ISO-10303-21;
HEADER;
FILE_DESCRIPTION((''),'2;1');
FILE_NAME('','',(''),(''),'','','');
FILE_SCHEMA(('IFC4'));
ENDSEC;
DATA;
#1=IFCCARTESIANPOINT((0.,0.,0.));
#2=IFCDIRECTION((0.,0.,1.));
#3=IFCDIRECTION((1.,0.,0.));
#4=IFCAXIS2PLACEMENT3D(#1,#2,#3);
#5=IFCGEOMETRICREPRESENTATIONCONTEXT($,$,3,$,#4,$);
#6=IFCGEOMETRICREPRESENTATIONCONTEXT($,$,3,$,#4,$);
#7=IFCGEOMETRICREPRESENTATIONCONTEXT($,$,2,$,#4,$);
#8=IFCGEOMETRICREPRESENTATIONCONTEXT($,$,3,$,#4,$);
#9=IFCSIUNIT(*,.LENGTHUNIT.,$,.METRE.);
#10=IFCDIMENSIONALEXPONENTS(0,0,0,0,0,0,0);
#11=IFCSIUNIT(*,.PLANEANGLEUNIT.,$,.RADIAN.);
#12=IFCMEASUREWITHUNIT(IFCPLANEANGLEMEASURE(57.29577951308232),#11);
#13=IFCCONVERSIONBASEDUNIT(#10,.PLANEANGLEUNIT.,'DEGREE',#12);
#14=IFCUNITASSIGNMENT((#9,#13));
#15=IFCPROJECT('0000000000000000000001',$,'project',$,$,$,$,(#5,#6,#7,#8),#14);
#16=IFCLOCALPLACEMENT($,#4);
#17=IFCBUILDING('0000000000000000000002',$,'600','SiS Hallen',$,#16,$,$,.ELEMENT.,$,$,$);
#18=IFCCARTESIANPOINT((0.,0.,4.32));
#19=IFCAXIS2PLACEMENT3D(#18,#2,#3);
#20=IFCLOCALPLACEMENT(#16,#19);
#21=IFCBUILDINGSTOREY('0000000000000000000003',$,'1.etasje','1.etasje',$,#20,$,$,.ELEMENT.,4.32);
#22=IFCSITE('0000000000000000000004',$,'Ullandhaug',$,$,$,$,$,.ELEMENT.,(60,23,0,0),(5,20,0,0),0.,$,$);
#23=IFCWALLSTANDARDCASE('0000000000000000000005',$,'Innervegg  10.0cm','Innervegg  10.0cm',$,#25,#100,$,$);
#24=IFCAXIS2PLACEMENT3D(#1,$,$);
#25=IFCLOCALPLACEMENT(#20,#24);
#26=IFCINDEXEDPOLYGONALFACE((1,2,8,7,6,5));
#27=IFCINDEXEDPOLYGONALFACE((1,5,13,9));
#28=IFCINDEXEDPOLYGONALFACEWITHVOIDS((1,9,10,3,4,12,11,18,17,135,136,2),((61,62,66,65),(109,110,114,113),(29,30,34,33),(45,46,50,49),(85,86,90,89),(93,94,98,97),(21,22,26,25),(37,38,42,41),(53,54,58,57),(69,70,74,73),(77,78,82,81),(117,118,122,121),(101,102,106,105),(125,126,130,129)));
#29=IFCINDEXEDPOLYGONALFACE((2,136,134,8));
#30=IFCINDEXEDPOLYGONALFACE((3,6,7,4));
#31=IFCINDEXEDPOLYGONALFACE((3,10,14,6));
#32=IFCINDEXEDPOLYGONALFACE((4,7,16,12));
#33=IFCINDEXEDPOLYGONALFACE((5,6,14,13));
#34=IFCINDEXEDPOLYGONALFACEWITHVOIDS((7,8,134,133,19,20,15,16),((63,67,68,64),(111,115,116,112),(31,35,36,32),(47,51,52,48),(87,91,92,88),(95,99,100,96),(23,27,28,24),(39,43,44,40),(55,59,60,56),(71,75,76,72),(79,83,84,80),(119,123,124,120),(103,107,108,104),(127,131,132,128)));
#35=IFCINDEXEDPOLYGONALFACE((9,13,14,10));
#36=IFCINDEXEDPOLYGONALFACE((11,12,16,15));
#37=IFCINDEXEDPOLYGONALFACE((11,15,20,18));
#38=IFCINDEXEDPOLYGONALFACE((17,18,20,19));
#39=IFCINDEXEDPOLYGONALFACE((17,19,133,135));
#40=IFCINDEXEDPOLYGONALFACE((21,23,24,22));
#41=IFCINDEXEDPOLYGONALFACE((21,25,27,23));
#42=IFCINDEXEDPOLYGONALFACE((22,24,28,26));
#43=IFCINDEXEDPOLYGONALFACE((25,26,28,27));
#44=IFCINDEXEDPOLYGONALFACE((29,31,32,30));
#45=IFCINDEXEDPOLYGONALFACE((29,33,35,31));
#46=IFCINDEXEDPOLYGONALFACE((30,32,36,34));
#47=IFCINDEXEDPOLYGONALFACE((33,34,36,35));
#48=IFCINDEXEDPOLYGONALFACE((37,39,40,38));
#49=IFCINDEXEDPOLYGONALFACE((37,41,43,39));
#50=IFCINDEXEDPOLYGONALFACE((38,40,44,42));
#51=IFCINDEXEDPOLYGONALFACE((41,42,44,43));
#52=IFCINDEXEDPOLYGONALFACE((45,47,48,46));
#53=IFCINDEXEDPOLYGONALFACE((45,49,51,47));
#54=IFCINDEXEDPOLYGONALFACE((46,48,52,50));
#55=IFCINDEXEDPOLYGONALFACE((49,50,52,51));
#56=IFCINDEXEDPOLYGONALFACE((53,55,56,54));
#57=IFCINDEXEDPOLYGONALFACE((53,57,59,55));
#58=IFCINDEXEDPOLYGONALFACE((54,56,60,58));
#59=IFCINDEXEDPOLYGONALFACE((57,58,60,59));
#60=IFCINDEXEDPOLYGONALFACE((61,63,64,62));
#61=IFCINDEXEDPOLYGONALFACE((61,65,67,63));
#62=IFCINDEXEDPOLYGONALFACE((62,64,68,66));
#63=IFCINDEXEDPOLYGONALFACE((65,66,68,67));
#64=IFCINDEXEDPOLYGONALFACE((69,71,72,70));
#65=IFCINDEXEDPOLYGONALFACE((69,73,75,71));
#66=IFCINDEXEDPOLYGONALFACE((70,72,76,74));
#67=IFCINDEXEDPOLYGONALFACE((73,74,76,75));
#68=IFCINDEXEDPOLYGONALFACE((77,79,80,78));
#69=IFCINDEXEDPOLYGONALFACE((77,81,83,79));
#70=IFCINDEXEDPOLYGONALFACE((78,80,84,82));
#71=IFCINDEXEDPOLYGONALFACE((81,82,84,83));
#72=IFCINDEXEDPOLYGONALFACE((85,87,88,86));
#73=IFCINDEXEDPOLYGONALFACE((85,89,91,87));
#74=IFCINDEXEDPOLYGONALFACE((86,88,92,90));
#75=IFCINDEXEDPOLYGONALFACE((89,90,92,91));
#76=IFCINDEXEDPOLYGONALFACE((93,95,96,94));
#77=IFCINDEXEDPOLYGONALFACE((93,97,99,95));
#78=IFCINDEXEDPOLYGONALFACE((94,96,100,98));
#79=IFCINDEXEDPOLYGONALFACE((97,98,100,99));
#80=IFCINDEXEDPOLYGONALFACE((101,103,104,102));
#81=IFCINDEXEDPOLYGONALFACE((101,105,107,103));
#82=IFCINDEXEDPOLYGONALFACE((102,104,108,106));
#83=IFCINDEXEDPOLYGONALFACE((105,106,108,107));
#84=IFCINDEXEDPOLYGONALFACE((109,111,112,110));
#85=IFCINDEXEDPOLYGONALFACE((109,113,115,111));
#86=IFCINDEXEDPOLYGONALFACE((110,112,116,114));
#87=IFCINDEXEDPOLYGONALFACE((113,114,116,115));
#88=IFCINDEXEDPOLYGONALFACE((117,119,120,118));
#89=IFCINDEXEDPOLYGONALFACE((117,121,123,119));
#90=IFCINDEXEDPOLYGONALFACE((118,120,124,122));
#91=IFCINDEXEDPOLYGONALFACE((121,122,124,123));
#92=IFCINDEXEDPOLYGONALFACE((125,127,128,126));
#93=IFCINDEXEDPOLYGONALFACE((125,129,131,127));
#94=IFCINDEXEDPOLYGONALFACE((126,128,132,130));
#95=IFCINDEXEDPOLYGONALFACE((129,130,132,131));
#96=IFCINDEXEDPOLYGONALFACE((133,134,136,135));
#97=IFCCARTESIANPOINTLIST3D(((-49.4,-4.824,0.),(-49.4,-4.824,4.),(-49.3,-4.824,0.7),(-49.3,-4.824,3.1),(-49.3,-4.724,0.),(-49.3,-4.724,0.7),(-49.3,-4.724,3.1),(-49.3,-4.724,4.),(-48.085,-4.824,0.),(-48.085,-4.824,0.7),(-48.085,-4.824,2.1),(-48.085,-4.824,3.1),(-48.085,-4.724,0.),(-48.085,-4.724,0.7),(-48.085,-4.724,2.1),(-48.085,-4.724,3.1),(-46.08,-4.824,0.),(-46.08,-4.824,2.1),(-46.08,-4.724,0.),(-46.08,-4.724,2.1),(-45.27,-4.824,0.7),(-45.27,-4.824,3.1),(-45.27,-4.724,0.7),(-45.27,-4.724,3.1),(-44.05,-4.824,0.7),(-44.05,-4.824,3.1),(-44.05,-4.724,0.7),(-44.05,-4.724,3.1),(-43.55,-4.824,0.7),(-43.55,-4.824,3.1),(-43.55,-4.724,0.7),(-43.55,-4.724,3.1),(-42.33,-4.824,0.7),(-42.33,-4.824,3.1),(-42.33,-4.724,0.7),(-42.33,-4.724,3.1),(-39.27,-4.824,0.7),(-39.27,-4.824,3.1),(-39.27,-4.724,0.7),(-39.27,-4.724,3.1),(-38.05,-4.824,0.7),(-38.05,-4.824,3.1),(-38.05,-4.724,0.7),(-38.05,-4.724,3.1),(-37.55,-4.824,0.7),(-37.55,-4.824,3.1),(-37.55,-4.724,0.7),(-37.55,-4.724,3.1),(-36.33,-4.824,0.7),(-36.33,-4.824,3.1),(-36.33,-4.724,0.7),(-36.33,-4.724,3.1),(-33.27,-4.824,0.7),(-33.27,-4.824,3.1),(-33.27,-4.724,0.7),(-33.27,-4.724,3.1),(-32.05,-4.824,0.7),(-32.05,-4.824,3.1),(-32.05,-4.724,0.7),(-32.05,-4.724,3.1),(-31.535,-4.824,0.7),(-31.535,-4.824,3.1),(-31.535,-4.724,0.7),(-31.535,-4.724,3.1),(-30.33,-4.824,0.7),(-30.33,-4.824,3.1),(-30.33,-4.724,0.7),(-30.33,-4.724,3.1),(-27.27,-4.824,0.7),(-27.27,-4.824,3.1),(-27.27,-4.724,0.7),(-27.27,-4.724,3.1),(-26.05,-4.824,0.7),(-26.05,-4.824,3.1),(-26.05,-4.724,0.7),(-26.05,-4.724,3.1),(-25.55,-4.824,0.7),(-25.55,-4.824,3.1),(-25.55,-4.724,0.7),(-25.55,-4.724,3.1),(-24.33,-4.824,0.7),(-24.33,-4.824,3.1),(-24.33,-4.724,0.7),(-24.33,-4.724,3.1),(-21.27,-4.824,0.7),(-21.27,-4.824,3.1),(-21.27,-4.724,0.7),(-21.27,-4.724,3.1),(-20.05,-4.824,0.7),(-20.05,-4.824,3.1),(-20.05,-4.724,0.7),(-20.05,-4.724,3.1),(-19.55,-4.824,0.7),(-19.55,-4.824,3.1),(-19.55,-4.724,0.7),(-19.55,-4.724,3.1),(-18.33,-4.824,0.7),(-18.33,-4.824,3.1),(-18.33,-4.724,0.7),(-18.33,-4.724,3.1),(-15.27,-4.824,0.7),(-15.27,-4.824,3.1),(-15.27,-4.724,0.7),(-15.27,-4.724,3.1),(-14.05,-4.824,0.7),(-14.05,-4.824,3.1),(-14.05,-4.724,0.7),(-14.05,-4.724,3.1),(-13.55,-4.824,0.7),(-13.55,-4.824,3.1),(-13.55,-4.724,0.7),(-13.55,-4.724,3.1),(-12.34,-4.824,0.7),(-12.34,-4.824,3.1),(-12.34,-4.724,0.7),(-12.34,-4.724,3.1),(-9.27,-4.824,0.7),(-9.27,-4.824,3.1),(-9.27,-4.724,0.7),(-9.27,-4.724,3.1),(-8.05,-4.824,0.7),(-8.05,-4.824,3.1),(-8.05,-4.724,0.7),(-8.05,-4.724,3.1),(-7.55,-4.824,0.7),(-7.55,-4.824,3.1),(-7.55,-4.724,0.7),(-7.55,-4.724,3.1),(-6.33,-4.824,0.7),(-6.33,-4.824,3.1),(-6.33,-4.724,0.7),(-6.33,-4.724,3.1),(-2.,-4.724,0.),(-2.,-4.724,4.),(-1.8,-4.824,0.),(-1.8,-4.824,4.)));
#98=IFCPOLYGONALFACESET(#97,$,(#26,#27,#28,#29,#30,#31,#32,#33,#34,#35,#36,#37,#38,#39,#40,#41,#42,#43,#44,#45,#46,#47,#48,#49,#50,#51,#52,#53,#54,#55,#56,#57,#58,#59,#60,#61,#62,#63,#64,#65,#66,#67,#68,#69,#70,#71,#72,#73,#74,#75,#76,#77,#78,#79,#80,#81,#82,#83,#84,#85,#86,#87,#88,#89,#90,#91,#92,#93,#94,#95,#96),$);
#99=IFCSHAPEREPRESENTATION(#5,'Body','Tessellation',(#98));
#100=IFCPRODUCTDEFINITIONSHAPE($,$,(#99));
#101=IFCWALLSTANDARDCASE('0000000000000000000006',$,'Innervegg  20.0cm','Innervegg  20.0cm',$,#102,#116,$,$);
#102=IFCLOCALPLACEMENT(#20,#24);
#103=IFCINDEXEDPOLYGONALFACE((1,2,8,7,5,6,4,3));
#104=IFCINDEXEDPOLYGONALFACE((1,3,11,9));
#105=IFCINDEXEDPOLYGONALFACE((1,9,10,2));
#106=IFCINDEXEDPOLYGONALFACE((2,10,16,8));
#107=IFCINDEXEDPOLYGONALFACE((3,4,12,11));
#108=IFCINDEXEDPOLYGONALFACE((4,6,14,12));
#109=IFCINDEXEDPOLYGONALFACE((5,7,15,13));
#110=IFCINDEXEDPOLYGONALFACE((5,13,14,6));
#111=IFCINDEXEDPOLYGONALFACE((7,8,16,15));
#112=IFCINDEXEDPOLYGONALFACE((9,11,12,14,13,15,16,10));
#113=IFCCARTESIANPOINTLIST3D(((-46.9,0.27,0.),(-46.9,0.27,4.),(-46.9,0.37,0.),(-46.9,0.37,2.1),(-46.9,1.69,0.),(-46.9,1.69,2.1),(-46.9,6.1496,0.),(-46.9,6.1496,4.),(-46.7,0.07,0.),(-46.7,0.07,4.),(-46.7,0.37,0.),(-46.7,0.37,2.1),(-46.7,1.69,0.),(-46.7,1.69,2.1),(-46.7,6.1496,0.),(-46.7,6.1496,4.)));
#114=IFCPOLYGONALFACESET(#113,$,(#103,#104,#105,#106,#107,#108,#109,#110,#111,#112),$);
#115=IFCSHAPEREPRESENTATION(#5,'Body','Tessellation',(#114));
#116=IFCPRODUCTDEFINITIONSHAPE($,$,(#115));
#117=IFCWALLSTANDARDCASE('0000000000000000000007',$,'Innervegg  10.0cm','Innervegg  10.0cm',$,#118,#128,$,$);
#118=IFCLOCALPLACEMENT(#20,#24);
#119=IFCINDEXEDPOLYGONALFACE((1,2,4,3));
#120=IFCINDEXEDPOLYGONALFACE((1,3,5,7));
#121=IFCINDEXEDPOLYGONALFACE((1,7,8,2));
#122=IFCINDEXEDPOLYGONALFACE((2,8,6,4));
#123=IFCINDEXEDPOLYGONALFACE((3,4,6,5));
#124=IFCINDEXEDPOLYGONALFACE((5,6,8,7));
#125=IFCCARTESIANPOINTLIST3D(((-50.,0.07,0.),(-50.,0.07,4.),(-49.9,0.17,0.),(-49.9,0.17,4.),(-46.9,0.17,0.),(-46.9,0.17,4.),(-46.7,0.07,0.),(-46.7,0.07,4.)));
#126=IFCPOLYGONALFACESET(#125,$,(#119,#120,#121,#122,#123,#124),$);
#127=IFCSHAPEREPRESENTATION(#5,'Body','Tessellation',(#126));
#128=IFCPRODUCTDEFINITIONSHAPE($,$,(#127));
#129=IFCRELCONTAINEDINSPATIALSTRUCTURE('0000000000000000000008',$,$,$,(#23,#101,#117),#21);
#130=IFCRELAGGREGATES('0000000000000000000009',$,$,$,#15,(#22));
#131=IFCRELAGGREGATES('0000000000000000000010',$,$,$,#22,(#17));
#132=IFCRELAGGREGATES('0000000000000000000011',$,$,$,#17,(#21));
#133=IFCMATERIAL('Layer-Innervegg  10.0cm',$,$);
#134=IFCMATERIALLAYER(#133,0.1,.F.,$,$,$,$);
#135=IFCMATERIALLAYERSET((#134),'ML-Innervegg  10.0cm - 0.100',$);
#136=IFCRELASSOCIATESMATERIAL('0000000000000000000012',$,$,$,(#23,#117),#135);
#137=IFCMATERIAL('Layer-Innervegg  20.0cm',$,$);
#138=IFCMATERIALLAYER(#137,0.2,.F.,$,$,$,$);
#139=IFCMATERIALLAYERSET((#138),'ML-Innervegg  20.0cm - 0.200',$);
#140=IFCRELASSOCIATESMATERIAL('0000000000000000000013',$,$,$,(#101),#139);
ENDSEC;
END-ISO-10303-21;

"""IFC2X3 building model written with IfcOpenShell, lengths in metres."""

from ifc_helpers import new_model, entity, si_unit, converted_unit, frame, origin_with_axes, place, context, project, spatial, polyline, outline, extrude, material, layer, layer_set, layer_usage, element, save


model = new_model("IFC2X3")

# Units and contexts
context_of_model_1 = context(None, 3, world=origin_with_axes())
context_of_model_2 = context(None, 3, world=origin_with_axes())
context_of_model_3 = context(None, 2, world=origin_with_axes())
context_of_model_4 = context(None, 3, world=origin_with_axes())
ifc_project = project(units=[si_unit("LENGTHUNIT", "METRE"), converted_unit("PLANEANGLEUNIT", "DEGREE", entity("IfcPlaneAngleMeasure", 57.29577951308232), si_unit("PLANEANGLEUNIT", "RADIAN"), dimensions=[0, 0, 0, 0, 0, 0, 0])], contexts=[context_of_model_1, context_of_model_2, context_of_model_3, context_of_model_4])

# Site, building, storey
site = spatial("IfcSite", under=ifc_project, Name="Ullandhaug", CompositionType="ELEMENT", RefLatitude=(60, 23, 0, 0), RefLongitude=(5, 20, 0, 0), RefElevation=0.0)
building_placement = place(None, origin_with_axes())
building = spatial("IfcBuilding", under=site, at=building_placement, Name="600", Description="SiS Hallen", CompositionType="ELEMENT")
storey_placement = place(building_placement, frame((0.0, 0.0, 4.32), z_axis=(0.0, 0.0, 1.0), x_axis=(1.0, 0.0, 0.0)))
storey = spatial("IfcBuildingStorey", under=building, at=storey_placement, Name="1.etasje", Description="1.etasje", CompositionType="ELEMENT", Elevation=4.32)

# Shared definitions
ifc_material_1 = material(Name="Layer-Innervegg  20.0cm")
ifc_layer_1 = layer(ifc_material_1, 0.2, ventilated=False)
ifc_layer_set_1 = layer_set([ifc_layer_1], Name="ML-Innervegg  20.0cm - 0.200")
ifc_layer_usage_1 = layer_usage(ifc_layer_set_1, "AXIS2", "POSITIVE", 0.0)
ifc_material_2 = material(Name="Layer-Innervegg  10.0cm")
ifc_layer_2 = layer(ifc_material_2, 0.1, ventilated=False)
ifc_layer_set_2 = layer_set([ifc_layer_2], Name="ML-Innervegg  10.0cm - 0.100")
ifc_layer_usage_2 = layer_usage(ifc_layer_set_2, "AXIS2", "POSITIVE", 0.0)

# Wall, openings
wall_1_placement = place(storey_placement, frame((-49.4, -4.824, 0.0), z_axis=(0.0, 0.0, 1.0), x_axis=(1.0, 0.0, 0.0)))
wall_1 = element("IfcWallStandardCase", 1, at=wall_1_placement, inside=storey, material=ifc_layer_usage_2, Name="Innervegg  10.0cm", Description="Innervegg  10.0cm", context=context_of_model_1, shape_type="SweptSolid", body=[
    extrude(outline(polyline([(0.0, 0.0), (47.6, 0.0), (47.4, 0.1), (0.1, 0.1), (0.0, 0.0)])), origin_with_axes(), (0.0, 0.0, 1.0), 4.0),
])
opening_1_placement = place(wall_1_placement, frame((1.315, 0.1, 0.0), z_axis=(0.0, 0.0, 1.0), x_axis=(1.0, 0.0, 0.0)))
element("IfcOpeningElement", 2, at=opening_1_placement, cuts=wall_1, context=context_of_model_1, shape_type="SweptSolid", body=[
    extrude(outline(polyline([(0.0, 0.0), (2.1, 0.0), (2.1, 2.005), (0.0, 2.005), (0.0, 0.0)])), frame((0.0, 0.0, 0.0), z_axis=(0.0, 1.0, 0.0), x_axis=(0.0, 0.0, 1.0)), (0.0, 0.0, -1.0), 0.1),
])
opening_2_placement = place(wall_1_placement, frame((0.1, 0.1, 0.7), z_axis=(0.0, 0.0, 1.0), x_axis=(1.0, 0.0, 0.0)))
element("IfcOpeningElement", 3, at=opening_2_placement, cuts=wall_1, context=context_of_model_1, shape_type="SweptSolid", body=[
    extrude(outline(polyline([(0.0, 0.0), (2.4, 0.0), (2.4, 1.215), (0.0, 1.215), (0.0, 0.0)])), frame((0.0, 0.0, 0.0), z_axis=(0.0, 1.0, 0.0), x_axis=(0.0, 0.0, 1.0)), (0.0, 0.0, -1.0), 0.1),
])
opening_3_placement = place(wall_1_placement, frame((4.13, 0.1, 0.7), z_axis=(0.0, 0.0, 1.0), x_axis=(1.0, 0.0, 0.0)))
element("IfcOpeningElement", 4, at=opening_3_placement, cuts=wall_1, context=context_of_model_1, shape_type="SweptSolid", body=[
    extrude(outline(polyline([(0.0, 0.0), (2.4, 0.0), (2.4, 1.22), (0.0, 1.22), (0.0, 0.0)])), frame((0.0, 0.0, 0.0), z_axis=(0.0, 1.0, 0.0), x_axis=(0.0, 0.0, 1.0)), (0.0, 0.0, -1.0), 0.1),
])
opening_4_placement = place(wall_1_placement, frame((5.85, 0.1, 0.7), z_axis=(0.0, 0.0, 1.0), x_axis=(1.0, 0.0, 0.0)))
element("IfcOpeningElement", 5, at=opening_4_placement, cuts=wall_1, context=context_of_model_1, shape_type="SweptSolid", body=[
    extrude(outline(polyline([(0.0, 0.0), (2.4, 0.0), (2.4, 1.22), (0.0, 1.22), (0.0, 0.0)])), frame((0.0, 0.0, 0.0), z_axis=(0.0, 1.0, 0.0), x_axis=(0.0, 0.0, 1.0)), (0.0, 0.0, -1.0), 0.1),
])
opening_5_placement = place(wall_1_placement, frame((10.13, 0.1, 0.7), z_axis=(0.0, 0.0, 1.0), x_axis=(1.0, 0.0, 0.0)))
element("IfcOpeningElement", 6, at=opening_5_placement, cuts=wall_1, context=context_of_model_1, shape_type="SweptSolid", body=[
    extrude(outline(polyline([(0.0, 0.0), (2.4, 0.0), (2.4, 1.22), (0.0, 1.22), (0.0, 0.0)])), frame((0.0, 0.0, 0.0), z_axis=(0.0, 1.0, 0.0), x_axis=(0.0, 0.0, 1.0)), (0.0, 0.0, -1.0), 0.1),
])
opening_6_placement = place(wall_1_placement, frame((11.85, 0.1, 0.7), z_axis=(0.0, 0.0, 1.0), x_axis=(1.0, 0.0, 0.0)))
element("IfcOpeningElement", 7, at=opening_6_placement, cuts=wall_1, context=context_of_model_1, shape_type="SweptSolid", body=[
    extrude(outline(polyline([(0.0, 0.0), (2.4, 0.0), (2.4, 1.22), (0.0, 1.22), (0.0, 0.0)])), frame((0.0, 0.0, 0.0), z_axis=(0.0, 1.0, 0.0), x_axis=(0.0, 0.0, 1.0)), (0.0, 0.0, -1.0), 0.1),
])
opening_7_placement = place(wall_1_placement, frame((16.13, 0.1, 0.7), z_axis=(0.0, 0.0, 1.0), x_axis=(1.0, 0.0, 0.0)))
element("IfcOpeningElement", 8, at=opening_7_placement, cuts=wall_1, context=context_of_model_1, shape_type="SweptSolid", body=[
    extrude(outline(polyline([(0.0, 0.0), (2.4, 0.0), (2.4, 1.22), (0.0, 1.22), (0.0, 0.0)])), frame((0.0, 0.0, 0.0), z_axis=(0.0, 1.0, 0.0), x_axis=(0.0, 0.0, 1.0)), (0.0, 0.0, -1.0), 0.1),
])
opening_8_placement = place(wall_1_placement, frame((22.13, 0.1, 0.7), z_axis=(0.0, 0.0, 1.0), x_axis=(1.0, 0.0, 0.0)))
element("IfcOpeningElement", 9, at=opening_8_placement, cuts=wall_1, context=context_of_model_1, shape_type="SweptSolid", body=[
    extrude(outline(polyline([(0.0, 0.0), (2.4, 0.0), (2.4, 1.22), (0.0, 1.22), (0.0, 0.0)])), frame((0.0, 0.0, 0.0), z_axis=(0.0, 1.0, 0.0), x_axis=(0.0, 0.0, 1.0)), (0.0, 0.0, -1.0), 0.1),
])
opening_9_placement = place(wall_1_placement, frame((23.85, 0.1, 0.7), z_axis=(0.0, 0.0, 1.0), x_axis=(1.0, 0.0, 0.0)))
element("IfcOpeningElement", 10, at=opening_9_placement, cuts=wall_1, context=context_of_model_1, shape_type="SweptSolid", body=[
    extrude(outline(polyline([(0.0, 0.0), (2.4, 0.0), (2.4, 1.22), (0.0, 1.22), (0.0, 0.0)])), frame((0.0, 0.0, 0.0), z_axis=(0.0, 1.0, 0.0), x_axis=(0.0, 0.0, 1.0)), (0.0, 0.0, -1.0), 0.1),
])
opening_10_placement = place(wall_1_placement, frame((28.13, 0.1, 0.7), z_axis=(0.0, 0.0, 1.0), x_axis=(1.0, 0.0, 0.0)))
element("IfcOpeningElement", 11, at=opening_10_placement, cuts=wall_1, context=context_of_model_1, shape_type="SweptSolid", body=[
    extrude(outline(polyline([(0.0, 0.0), (2.4, 0.0), (2.4, 1.22), (0.0, 1.22), (0.0, 0.0)])), frame((0.0, 0.0, 0.0), z_axis=(0.0, 1.0, 0.0), x_axis=(0.0, 0.0, 1.0)), (0.0, 0.0, -1.0), 0.1),
])
opening_11_placement = place(wall_1_placement, frame((29.85, 0.1, 0.7), z_axis=(0.0, 0.0, 1.0), x_axis=(1.0, 0.0, 0.0)))
element("IfcOpeningElement", 12, at=opening_11_placement, cuts=wall_1, context=context_of_model_1, shape_type="SweptSolid", body=[
    extrude(outline(polyline([(0.0, 0.0), (2.4, 0.0), (2.4, 1.22), (0.0, 1.22), (0.0, 0.0)])), frame((0.0, 0.0, 0.0), z_axis=(0.0, 1.0, 0.0), x_axis=(0.0, 0.0, 1.0)), (0.0, 0.0, -1.0), 0.1),
])
opening_12_placement = place(wall_1_placement, frame((34.13, 0.1, 0.7), z_axis=(0.0, 0.0, 1.0), x_axis=(1.0, 0.0, 0.0)))
element("IfcOpeningElement", 13, at=opening_12_placement, cuts=wall_1, context=context_of_model_1, shape_type="SweptSolid", body=[
    extrude(outline(polyline([(0.0, 0.0), (2.4, 0.0), (2.4, 1.22), (0.0, 1.22), (0.0, 0.0)])), frame((0.0, 0.0, 0.0), z_axis=(0.0, 1.0, 0.0), x_axis=(0.0, 0.0, 1.0)), (0.0, 0.0, -1.0), 0.1),
])
opening_13_placement = place(wall_1_placement, frame((35.85, 0.1, 0.7), z_axis=(0.0, 0.0, 1.0), x_axis=(1.0, 0.0, 0.0)))
element("IfcOpeningElement", 14, at=opening_13_placement, cuts=wall_1, context=context_of_model_1, shape_type="SweptSolid", body=[
    extrude(outline(polyline([(0.0, 0.0), (2.4, 0.0), (2.4, 1.21), (0.0, 1.21), (0.0, 0.0)])), frame((0.0, 0.0, 0.0), z_axis=(0.0, 1.0, 0.0), x_axis=(0.0, 0.0, 1.0)), (0.0, 0.0, -1.0), 0.1),
])
opening_14_placement = place(wall_1_placement, frame((40.13, 0.1, 0.7), z_axis=(0.0, 0.0, 1.0), x_axis=(1.0, 0.0, 0.0)))
element("IfcOpeningElement", 15, at=opening_14_placement, cuts=wall_1, context=context_of_model_1, shape_type="SweptSolid", body=[
    extrude(outline(polyline([(0.0, 0.0), (2.4, 0.0), (2.4, 1.22), (0.0, 1.22), (0.0, 0.0)])), frame((0.0, 0.0, 0.0), z_axis=(0.0, 1.0, 0.0), x_axis=(0.0, 0.0, 1.0)), (0.0, 0.0, -1.0), 0.1),
])
opening_15_placement = place(wall_1_placement, frame((41.85, 0.1, 0.7), z_axis=(0.0, 0.0, 1.0), x_axis=(1.0, 0.0, 0.0)))
element("IfcOpeningElement", 16, at=opening_15_placement, cuts=wall_1, context=context_of_model_1, shape_type="SweptSolid", body=[
    extrude(outline(polyline([(0.0, 0.0), (2.4, 0.0), (2.4, 1.22), (0.0, 1.22), (0.0, 0.0)])), frame((0.0, 0.0, 0.0), z_axis=(0.0, 1.0, 0.0), x_axis=(0.0, 0.0, 1.0)), (0.0, 0.0, -1.0), 0.1),
])
opening_16_placement = place(wall_1_placement, frame((17.865, 0.1, 0.7), z_axis=(0.0, 0.0, 1.0), x_axis=(1.0, 0.0, 0.0)))
element("IfcOpeningElement", 17, at=opening_16_placement, cuts=wall_1, context=context_of_model_1, shape_type="SweptSolid", body=[
    extrude(outline(polyline([(0.0, 0.0), (2.4, 0.0), (2.4, 1.205), (0.0, 1.205), (0.0, 0.0)])), frame((0.0, 0.0, 0.0), z_axis=(0.0, 1.0, 0.0), x_axis=(0.0, 0.0, 1.0)), (0.0, 0.0, -1.0), 0.1),
])

# Wall, opening
wall_2_placement = place(storey_placement, frame((-46.9, 6.1496, 0.0), z_axis=(0.0, 0.0, 1.0), x_axis=(0.0, -1.0, 0.0)))
wall_2 = element("IfcWallStandardCase", 18, at=wall_2_placement, inside=storey, material=ifc_layer_usage_1, Name="Innervegg  20.0cm", Description="Innervegg  20.0cm", context=context_of_model_1, shape_type="SweptSolid", body=[
    extrude(outline(polyline([(0.0, 0.0), (5.8796, 0.0), (6.0796, 0.2), (0.0, 0.2), (0.0, 0.0)])), frame((0.0, 0.0, 0.0), z_axis=(0.0, 0.0, 1.0), x_axis=(1.0, 0.0, 0.0)), (0.0, 0.0, 1.0), 4.0),
])
opening_17_placement = place(wall_2_placement, frame((4.4596, 0.2, 0.0), z_axis=(0.0, 0.0, 1.0), x_axis=(1.0, 0.0, 0.0)))
element("IfcOpeningElement", 19, at=opening_17_placement, cuts=wall_2, context=context_of_model_1, shape_type="SweptSolid", body=[
    extrude(outline(polyline([(0.0, 0.0), (2.1, 0.0), (2.1, 1.32), (0.0, 1.32), (0.0, 0.0)])), frame((0.0, 0.0, 0.0), z_axis=(0.0, 1.0, 0.0), x_axis=(0.0, 0.0, 1.0)), (0.0, 0.0, -1.0), 0.2),
])

# Wall
wall_3_placement = place(storey_placement, frame((-46.9, 0.17, 0.0), z_axis=(0.0, 0.0, 1.0), x_axis=(-1.0, 0.0, 0.0)))
element("IfcWallStandardCase", 20, at=wall_3_placement, inside=storey, material=ifc_layer_usage_2, Name="Innervegg  10.0cm", Description="Innervegg  10.0cm", context=context_of_model_1, shape_type="SweptSolid", body=[
    extrude(outline(polyline([(0.0, 0.0), (3.0, 0.0), (3.1, 0.1), (-0.2, 0.1), (0.0, 0.0)])), frame((0.0, 0.0, 0.0), z_axis=(0.0, 0.0, 1.0), x_axis=(1.0, 0.0, 0.0)), (0.0, 0.0, 1.0), 4.0),
])

save(model, "model.ifc")
